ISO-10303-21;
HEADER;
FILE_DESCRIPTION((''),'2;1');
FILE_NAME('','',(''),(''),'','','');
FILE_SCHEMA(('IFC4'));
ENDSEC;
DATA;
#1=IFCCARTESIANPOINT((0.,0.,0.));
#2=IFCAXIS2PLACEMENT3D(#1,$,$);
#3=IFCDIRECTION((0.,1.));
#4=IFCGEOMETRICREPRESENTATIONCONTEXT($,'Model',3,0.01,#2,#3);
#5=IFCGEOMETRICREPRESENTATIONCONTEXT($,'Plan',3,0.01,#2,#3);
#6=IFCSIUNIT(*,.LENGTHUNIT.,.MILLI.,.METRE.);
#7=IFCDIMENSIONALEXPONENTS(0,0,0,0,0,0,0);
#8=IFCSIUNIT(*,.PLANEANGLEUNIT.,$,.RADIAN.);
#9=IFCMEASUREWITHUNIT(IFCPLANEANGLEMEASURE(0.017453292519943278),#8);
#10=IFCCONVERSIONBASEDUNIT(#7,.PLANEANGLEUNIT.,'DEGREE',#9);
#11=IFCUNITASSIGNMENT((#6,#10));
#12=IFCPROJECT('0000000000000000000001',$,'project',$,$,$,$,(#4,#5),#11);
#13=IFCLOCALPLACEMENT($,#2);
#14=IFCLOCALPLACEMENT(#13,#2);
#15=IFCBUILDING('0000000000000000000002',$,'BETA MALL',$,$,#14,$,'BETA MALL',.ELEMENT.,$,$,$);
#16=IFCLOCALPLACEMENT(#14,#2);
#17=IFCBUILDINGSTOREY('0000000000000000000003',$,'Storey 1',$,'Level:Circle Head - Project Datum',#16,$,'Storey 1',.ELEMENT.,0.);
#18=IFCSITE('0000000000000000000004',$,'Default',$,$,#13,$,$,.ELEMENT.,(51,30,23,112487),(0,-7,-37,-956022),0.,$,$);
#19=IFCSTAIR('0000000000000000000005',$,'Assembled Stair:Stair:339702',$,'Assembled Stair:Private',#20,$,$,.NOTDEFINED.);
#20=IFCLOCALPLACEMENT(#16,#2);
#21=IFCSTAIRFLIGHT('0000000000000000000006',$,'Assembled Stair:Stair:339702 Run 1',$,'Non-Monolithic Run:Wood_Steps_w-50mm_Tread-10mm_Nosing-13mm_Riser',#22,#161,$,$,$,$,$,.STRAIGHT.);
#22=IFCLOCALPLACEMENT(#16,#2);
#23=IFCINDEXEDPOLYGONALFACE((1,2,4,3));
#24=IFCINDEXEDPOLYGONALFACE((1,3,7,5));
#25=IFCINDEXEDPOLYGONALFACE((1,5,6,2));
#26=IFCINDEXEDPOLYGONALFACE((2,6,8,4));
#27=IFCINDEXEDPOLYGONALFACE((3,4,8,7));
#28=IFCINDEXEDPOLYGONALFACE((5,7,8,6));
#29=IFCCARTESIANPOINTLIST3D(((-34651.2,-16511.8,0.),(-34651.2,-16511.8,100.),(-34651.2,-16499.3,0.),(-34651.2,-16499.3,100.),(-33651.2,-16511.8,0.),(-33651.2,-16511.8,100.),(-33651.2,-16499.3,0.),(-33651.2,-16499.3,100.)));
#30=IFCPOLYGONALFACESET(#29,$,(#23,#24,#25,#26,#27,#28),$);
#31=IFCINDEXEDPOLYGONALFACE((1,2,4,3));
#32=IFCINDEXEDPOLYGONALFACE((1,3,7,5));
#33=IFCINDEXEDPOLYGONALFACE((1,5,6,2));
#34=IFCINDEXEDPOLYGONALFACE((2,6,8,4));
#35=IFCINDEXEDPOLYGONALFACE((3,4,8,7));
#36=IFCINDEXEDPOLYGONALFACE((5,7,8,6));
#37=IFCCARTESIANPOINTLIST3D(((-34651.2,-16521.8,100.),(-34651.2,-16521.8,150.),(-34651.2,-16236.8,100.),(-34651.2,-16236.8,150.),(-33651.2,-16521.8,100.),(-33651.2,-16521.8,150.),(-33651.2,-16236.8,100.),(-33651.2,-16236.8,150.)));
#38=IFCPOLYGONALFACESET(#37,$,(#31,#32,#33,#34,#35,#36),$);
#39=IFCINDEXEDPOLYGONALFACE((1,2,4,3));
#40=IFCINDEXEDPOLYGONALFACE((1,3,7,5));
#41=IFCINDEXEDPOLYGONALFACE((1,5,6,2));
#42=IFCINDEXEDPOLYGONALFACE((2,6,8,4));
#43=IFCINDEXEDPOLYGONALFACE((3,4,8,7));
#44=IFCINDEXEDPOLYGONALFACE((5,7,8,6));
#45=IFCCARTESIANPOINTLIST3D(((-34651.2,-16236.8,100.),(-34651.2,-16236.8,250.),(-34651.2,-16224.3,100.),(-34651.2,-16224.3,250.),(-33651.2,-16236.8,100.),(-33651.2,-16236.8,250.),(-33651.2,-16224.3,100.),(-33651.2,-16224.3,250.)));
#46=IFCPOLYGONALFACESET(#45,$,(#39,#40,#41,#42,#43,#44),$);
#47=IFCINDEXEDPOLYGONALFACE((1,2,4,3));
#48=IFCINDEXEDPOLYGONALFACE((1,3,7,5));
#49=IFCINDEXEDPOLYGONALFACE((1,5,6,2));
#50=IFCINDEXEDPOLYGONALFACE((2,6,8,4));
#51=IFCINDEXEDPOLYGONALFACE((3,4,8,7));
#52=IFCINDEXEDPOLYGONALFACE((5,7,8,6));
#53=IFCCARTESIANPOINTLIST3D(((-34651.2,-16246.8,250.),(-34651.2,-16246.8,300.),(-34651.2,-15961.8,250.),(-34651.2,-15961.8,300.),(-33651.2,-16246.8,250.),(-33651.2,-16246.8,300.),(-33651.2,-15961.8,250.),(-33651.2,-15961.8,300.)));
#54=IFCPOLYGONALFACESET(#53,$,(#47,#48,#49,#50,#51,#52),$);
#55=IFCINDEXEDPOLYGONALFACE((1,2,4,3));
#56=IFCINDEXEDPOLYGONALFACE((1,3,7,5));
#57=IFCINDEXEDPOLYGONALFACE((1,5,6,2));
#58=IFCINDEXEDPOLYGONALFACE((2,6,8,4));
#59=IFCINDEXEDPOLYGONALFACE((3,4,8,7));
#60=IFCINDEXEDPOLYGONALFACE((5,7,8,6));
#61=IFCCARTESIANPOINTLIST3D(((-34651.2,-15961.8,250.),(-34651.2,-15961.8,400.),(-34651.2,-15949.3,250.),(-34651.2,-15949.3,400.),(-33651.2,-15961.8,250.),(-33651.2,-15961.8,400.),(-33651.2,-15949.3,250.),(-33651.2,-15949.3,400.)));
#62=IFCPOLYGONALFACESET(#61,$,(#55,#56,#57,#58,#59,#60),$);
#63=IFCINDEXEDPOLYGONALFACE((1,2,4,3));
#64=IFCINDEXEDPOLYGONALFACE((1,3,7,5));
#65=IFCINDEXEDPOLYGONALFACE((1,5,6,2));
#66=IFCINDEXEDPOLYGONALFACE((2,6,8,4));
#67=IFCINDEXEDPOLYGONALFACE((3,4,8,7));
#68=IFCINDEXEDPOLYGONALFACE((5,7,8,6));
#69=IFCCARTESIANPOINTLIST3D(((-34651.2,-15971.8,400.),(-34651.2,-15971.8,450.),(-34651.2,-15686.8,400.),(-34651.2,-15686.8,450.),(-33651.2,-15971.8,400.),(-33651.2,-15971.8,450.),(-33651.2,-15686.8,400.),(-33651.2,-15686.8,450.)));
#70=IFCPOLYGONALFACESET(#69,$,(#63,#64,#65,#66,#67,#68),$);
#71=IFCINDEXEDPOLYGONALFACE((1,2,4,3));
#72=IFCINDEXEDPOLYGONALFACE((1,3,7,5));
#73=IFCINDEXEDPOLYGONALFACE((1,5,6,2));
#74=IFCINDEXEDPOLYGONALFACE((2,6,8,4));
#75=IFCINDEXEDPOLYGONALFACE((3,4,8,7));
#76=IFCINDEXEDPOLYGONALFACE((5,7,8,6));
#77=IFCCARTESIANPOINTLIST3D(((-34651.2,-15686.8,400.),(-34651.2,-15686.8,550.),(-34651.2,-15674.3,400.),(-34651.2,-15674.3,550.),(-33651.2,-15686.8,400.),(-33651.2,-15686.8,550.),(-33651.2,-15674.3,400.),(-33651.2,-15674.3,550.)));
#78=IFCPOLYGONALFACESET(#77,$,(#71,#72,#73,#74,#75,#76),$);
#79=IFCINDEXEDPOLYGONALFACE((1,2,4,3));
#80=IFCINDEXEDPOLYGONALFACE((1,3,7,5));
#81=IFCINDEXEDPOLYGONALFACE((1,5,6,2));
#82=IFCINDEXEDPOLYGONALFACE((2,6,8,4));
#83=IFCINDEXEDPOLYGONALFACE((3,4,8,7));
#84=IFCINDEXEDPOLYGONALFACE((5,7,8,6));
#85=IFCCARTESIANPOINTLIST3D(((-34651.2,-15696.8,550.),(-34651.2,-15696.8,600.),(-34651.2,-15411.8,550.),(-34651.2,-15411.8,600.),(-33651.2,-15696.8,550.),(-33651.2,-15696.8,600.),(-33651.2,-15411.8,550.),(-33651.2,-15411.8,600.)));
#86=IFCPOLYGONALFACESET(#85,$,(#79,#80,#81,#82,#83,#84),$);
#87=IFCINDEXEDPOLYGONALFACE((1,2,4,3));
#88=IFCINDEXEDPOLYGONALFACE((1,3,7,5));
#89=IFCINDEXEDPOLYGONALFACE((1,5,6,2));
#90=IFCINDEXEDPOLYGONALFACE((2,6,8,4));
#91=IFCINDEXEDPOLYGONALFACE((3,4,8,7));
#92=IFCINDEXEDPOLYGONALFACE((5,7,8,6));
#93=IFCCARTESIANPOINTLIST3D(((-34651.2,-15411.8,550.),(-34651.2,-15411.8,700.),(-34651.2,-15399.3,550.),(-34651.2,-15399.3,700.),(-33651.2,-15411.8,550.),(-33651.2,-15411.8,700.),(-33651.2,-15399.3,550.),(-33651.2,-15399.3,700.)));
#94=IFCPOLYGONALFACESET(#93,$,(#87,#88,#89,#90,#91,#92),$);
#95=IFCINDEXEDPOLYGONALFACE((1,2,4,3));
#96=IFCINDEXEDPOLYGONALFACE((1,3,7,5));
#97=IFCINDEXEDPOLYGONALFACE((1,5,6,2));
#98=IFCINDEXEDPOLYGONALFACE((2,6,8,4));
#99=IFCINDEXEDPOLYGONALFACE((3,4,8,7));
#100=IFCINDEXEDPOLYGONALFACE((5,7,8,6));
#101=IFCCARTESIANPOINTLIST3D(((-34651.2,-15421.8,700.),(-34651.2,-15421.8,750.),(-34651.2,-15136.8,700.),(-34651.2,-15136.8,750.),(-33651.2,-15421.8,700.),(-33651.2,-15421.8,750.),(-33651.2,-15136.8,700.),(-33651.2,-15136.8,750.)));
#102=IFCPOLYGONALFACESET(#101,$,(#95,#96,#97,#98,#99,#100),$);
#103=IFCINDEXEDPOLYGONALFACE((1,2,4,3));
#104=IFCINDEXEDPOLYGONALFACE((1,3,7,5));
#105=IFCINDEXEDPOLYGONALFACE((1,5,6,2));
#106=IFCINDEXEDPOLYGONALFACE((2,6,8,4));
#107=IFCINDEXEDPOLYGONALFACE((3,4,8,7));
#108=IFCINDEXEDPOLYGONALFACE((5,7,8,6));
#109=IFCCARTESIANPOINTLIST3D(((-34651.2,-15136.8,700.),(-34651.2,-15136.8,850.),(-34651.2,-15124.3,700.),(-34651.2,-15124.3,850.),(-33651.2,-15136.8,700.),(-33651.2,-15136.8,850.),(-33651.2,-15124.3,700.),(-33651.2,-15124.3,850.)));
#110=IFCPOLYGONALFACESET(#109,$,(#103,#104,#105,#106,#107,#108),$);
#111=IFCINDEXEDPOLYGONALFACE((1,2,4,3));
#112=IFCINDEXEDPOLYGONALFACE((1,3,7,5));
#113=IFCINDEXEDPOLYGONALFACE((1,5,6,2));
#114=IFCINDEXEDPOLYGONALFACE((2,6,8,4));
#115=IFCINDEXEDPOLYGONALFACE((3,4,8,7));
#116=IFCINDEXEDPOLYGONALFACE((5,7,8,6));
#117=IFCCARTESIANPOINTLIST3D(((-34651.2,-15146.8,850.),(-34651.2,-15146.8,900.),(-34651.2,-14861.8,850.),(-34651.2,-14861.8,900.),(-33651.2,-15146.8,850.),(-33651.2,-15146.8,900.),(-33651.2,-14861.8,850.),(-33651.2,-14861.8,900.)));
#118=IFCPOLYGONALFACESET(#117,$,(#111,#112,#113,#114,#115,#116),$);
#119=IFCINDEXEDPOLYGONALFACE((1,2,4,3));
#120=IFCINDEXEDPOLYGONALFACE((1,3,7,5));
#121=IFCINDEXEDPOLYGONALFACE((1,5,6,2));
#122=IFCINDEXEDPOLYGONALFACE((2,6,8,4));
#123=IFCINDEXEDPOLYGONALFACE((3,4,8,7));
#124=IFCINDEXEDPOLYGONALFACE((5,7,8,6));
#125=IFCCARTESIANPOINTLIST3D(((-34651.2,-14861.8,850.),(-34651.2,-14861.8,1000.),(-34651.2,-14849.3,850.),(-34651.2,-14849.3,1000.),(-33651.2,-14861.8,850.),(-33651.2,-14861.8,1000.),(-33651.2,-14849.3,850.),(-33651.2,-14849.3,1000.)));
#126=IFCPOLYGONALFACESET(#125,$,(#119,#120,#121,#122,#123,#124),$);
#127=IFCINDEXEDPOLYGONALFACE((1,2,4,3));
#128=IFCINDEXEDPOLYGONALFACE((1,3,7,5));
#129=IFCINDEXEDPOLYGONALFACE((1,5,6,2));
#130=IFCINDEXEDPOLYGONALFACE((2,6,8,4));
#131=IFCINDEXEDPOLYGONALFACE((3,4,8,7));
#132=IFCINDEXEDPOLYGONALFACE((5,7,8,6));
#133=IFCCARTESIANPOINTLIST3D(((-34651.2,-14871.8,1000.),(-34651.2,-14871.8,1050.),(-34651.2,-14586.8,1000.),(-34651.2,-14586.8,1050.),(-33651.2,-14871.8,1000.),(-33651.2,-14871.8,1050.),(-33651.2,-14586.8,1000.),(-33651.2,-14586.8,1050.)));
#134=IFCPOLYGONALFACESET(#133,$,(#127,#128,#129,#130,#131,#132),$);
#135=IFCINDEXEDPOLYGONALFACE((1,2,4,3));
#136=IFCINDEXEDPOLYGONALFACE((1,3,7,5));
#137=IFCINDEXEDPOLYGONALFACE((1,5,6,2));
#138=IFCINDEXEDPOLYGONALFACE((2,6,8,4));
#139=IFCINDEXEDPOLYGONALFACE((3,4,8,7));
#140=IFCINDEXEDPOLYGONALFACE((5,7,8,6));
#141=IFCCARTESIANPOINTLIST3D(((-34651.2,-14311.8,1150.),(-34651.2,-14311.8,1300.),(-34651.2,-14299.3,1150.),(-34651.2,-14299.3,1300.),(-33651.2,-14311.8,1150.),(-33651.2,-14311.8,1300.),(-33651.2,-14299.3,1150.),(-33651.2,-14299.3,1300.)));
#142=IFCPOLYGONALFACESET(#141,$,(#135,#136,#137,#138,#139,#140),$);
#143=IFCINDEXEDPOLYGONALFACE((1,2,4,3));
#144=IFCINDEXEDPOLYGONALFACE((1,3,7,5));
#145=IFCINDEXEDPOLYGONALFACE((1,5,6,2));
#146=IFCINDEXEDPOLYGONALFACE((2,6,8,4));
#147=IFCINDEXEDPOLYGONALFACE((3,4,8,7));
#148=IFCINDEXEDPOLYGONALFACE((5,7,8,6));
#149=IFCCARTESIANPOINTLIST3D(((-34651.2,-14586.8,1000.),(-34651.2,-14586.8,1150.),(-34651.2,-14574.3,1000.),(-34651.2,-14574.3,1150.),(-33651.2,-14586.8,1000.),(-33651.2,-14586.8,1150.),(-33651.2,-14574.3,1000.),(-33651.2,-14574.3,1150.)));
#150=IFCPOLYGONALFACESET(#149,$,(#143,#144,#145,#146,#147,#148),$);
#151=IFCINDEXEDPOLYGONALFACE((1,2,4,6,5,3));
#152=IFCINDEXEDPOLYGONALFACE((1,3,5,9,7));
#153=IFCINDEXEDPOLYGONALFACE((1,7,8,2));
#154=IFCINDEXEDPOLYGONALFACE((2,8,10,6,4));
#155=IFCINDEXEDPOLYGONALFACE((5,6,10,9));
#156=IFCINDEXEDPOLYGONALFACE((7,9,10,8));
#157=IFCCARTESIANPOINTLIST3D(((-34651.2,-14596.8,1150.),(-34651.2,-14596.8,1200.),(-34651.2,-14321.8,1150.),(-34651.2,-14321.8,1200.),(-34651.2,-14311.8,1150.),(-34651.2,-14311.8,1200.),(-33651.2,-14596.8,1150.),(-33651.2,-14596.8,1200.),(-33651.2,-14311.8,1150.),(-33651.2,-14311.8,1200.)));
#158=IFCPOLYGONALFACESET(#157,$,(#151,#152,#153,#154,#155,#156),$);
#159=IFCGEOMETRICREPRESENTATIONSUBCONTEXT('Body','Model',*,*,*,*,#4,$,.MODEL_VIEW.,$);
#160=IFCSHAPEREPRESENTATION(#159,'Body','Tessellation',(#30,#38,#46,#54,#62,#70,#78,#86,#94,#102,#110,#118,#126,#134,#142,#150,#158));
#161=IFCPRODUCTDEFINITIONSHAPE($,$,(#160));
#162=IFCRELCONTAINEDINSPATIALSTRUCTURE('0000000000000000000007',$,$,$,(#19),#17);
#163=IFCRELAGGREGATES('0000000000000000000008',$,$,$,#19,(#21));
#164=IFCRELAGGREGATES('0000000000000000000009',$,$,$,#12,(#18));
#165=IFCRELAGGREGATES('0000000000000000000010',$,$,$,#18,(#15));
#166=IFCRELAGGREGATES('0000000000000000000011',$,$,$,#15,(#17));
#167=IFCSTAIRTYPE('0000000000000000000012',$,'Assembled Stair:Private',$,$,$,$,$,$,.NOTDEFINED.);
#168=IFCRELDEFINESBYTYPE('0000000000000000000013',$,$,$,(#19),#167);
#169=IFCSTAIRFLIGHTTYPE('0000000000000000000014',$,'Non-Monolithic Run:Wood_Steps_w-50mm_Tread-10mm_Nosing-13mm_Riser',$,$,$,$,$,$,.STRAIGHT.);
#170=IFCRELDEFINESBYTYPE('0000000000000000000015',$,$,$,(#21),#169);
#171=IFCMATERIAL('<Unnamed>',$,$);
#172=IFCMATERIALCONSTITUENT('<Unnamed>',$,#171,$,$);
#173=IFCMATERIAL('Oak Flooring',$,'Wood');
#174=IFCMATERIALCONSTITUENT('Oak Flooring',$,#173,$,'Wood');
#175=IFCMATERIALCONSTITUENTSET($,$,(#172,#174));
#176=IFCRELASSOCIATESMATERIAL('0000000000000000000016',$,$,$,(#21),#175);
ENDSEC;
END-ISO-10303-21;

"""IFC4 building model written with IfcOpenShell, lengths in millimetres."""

from ifc_helpers import new_model, entity, si_unit, converted_unit, direction, frame, origin, place, context, subcontext, project, spatial, indexed_curve, outline, extrude, material, constituent, constituent_set, type_object, element, aggregate, save


model = new_model("IFC4")

# Units and contexts
model_context = context("Model", 3, precision=0.01, world=origin(), true_north=direction((0.0, 1.0)))
plan_context = context("Plan", 3, precision=0.01, world=origin(), true_north=direction((0.0, 1.0)))
body_context = subcontext(model_context, "Body", "Model", "MODEL_VIEW")
ifc_project = project(units=[si_unit("LENGTHUNIT", "METRE", prefix="MILLI"), converted_unit("PLANEANGLEUNIT", "DEGREE", entity("IfcPlaneAngleMeasure", 0.017453292519943278), si_unit("PLANEANGLEUNIT", "RADIAN"), dimensions=[0, 0, 0, 0, 0, 0, 0])], contexts=[model_context, plan_context])

# Site, building, storey
site_placement = place(None, origin())
site = spatial("IfcSite", under=ifc_project, at=site_placement, Name="Default", CompositionType="ELEMENT", RefLatitude=(51, 30, 23, 112487), RefLongitude=(0, -7, -37, -956022), RefElevation=0.0)
building_placement = place(site_placement, origin())
building = spatial("IfcBuilding", under=site, at=building_placement, Name="BETA MALL", LongName="BETA MALL", CompositionType="ELEMENT")
storey_placement = place(building_placement, origin())
storey = spatial("IfcBuildingStorey", under=building, at=storey_placement, Name="Storey 1", ObjectType="Level:Circle Head - Project Datum", LongName="Storey 1", CompositionType="ELEMENT", Elevation=0.0)

# Shared definitions
ifc_material_1 = material(Name="<Unnamed>")

# Stair
stair_type_1 = type_object("IfcStairType", Name="Assembled Stair:Private", PredefinedType="NOTDEFINED")
stair_1_placement = place(storey_placement, origin())
stair_1 = element("IfcStair", 1, at=stair_1_placement, inside=storey, type_object=stair_type_1, Name="Assembled Stair:Stair:339702", ObjectType="Assembled Stair:Private", PredefinedType="NOTDEFINED")
ifc_material_2 = material(Name="Oak Flooring", Category="Wood")

# Stair flight
ifc_constituent_1 = constituent(ifc_material_1, Name="<Unnamed>")
ifc_constituent_2 = constituent(ifc_material_2, Name="Oak Flooring", Category="Wood")
ifc_constituent_set_1 = constituent_set(constituents=[ifc_constituent_1, ifc_constituent_2])
stair_flight_type_1 = type_object("IfcStairFlightType", Name="Non-Monolithic Run:Wood_Steps_w-50mm_Tread-10mm_Nosing-13mm_Riser", PredefinedType="STRAIGHT")
stair_flight_1_placement = place(stair_1_placement, origin())
stair_flight_1 = element("IfcStairFlight", 2, at=stair_flight_1_placement, type_object=stair_flight_type_1, material=ifc_constituent_set_1, Name="Assembled Stair:Stair:339702 Run 1", ObjectType="Non-Monolithic Run:Wood_Steps_w-50mm_Tread-10mm_Nosing-13mm_Riser", PredefinedType="STRAIGHT", context=body_context, shape_type="SweptSolid", body=[
    extrude(outline(indexed_curve([(-500.0, -6.2), (500.0, -6.2), (500.0, 6.3), (-500.0, 6.3), (-500.0, -6.2)], self_intersect=False)), frame((-34151.2, -16505.6, 0.0), z_axis=(0.0, 0.0, 1.0), x_axis=(-1.0, 0.0, 0.0)), (0.0, 0.0, 1.0), 100.0),
    extrude(outline(indexed_curve([(-142.5, -500.0), (142.5, -500.0), (142.5, 500.0), (-142.5, 500.0), (-142.5, -500.0)], self_intersect=False)), frame((-34151.2, -16379.3, 100.0), z_axis=(0.0, 0.0, 1.0), x_axis=(0.0, -1.0, 0.0)), (0.0, 0.0, 1.0), 50.0),
    extrude(outline(indexed_curve([(-500.0, -6.2), (500.0, -6.2), (500.0, 6.3), (-500.0, 6.3), (-500.0, -6.2)], self_intersect=False)), frame((-34151.2, -16230.6, 100.0), z_axis=(0.0, 0.0, 1.0), x_axis=(-1.0, 0.0, 0.0)), (0.0, 0.0, 1.0), 150.0),
    extrude(outline(indexed_curve([(-142.5, -500.0), (142.5, -500.0), (142.5, 500.0), (-142.5, 500.0), (-142.5, -500.0)], self_intersect=False)), frame((-34151.2, -16104.3, 250.0), z_axis=(0.0, 0.0, 1.0), x_axis=(0.0, -1.0, 0.0)), (0.0, 0.0, 1.0), 50.0),
    extrude(outline(indexed_curve([(-500.0, -6.3), (500.0, -6.3), (500.0, 6.2), (-500.0, 6.2), (-500.0, -6.3)], self_intersect=False)), frame((-34151.2, -15955.6, 250.0), z_axis=(0.0, 0.0, 1.0), x_axis=(-1.0, 0.0, 0.0)), (0.0, 0.0, 1.0), 150.0),
    extrude(outline(indexed_curve([(-142.5, -500.0), (142.5, -500.0), (142.5, 500.0), (-142.5, 500.0), (-142.5, -500.0)], self_intersect=False)), frame((-34151.2, -15829.3, 400.0), z_axis=(0.0, 0.0, 1.0), x_axis=(0.0, -1.0, 0.0)), (0.0, 0.0, 1.0), 50.0),
    extrude(outline(indexed_curve([(-500.0, -6.3), (500.0, -6.3), (500.0, 6.2), (-500.0, 6.2), (-500.0, -6.3)], self_intersect=False)), frame((-34151.2, -15680.6, 400.0), z_axis=(0.0, 0.0, 1.0), x_axis=(-1.0, 0.0, 0.0)), (0.0, 0.0, 1.0), 150.0),
    extrude(outline(indexed_curve([(-142.5, -500.0), (142.5, -500.0), (142.5, 500.0), (-142.5, 500.0), (-142.5, -500.0)], self_intersect=False)), frame((-34151.2, -15554.3, 550.0), z_axis=(0.0, 0.0, 1.0), x_axis=(0.0, -1.0, 0.0)), (0.0, 0.0, 1.0), 50.0),
    extrude(outline(indexed_curve([(-500.0, -6.3), (500.0, -6.3), (500.0, 6.2), (-500.0, 6.2), (-500.0, -6.3)], self_intersect=False)), frame((-34151.2, -15405.6, 550.0), z_axis=(0.0, 0.0, 1.0), x_axis=(-1.0, 0.0, 0.0)), (0.0, 0.0, 1.0), 150.0),
    extrude(outline(indexed_curve([(-142.5, -500.0), (142.5, -500.0), (142.5, 500.0), (-142.5, 500.0), (-142.5, -500.0)], self_intersect=False)), frame((-34151.2, -15279.3, 700.0), z_axis=(0.0, 0.0, 1.0), x_axis=(0.0, -1.0, 0.0)), (0.0, 0.0, 1.0), 50.0),
    extrude(outline(indexed_curve([(-500.0, -6.2), (500.0, -6.2), (500.0, 6.3), (-500.0, 6.3), (-500.0, -6.2)], self_intersect=False)), frame((-34151.2, -15130.6, 700.0), z_axis=(0.0, 0.0, 1.0), x_axis=(-1.0, 0.0, 0.0)), (0.0, 0.0, 1.0), 150.0),
    extrude(outline(indexed_curve([(-142.5, -500.0), (142.5, -500.0), (142.5, 500.0), (-142.5, 500.0), (-142.5, -500.0)], self_intersect=False)), frame((-34151.2, -15004.3, 850.0), z_axis=(0.0, 0.0, 1.0), x_axis=(0.0, -1.0, 0.0)), (0.0, 0.0, 1.0), 50.0),
    extrude(outline(indexed_curve([(-500.0, -6.2), (500.0, -6.2), (500.0, 6.3), (-500.0, 6.3), (-500.0, -6.2)], self_intersect=False)), frame((-34151.2, -14855.6, 850.0), z_axis=(0.0, 0.0, 1.0), x_axis=(-1.0, 0.0, 0.0)), (0.0, 0.0, 1.0), 150.0),
    extrude(outline(indexed_curve([(-142.5, -500.0), (142.5, -500.0), (142.5, 500.0), (-142.5, 500.0), (-142.5, -500.0)], self_intersect=False)), frame((-34151.2, -14729.3, 1000.0), z_axis=(0.0, 0.0, 1.0), x_axis=(0.0, -1.0, 0.0)), (0.0, 0.0, 1.0), 50.0),
    extrude(outline(indexed_curve([(-500.0, -6.3), (500.0, -6.3), (500.0, 6.2), (-500.0, 6.2), (-500.0, -6.3)], self_intersect=False)), frame((-34151.2, -14305.6, 1150.0), z_axis=(0.0, 0.0, 1.0), x_axis=(-1.0, 0.0, 0.0)), (0.0, 0.0, 1.0), 150.0),
    extrude(outline(indexed_curve([(-500.0, -6.3), (500.0, -6.3), (500.0, 6.2), (-500.0, 6.2), (-500.0, -6.3)], self_intersect=False)), frame((-34151.2, -14580.6, 1000.0), z_axis=(0.0, 0.0, 1.0), x_axis=(-1.0, 0.0, 0.0)), (0.0, 0.0, 1.0), 150.0),
    extrude(outline(indexed_curve([(-116.0, -400.0), (-106.0, -400.0), (169.0, -400.0), (169.0, 600.0), (-116.0, 600.0), (-116.0, -400.0)], self_intersect=False)), frame((-34251.2, -14427.8, 1150.0), z_axis=(0.0, 0.0, 1.0), x_axis=(0.0, -1.0, 0.0)), (0.0, 0.0, 1.0), 50.0),
])
aggregate(stair_1, [stair_flight_1])

save(model, "model.ifc")
